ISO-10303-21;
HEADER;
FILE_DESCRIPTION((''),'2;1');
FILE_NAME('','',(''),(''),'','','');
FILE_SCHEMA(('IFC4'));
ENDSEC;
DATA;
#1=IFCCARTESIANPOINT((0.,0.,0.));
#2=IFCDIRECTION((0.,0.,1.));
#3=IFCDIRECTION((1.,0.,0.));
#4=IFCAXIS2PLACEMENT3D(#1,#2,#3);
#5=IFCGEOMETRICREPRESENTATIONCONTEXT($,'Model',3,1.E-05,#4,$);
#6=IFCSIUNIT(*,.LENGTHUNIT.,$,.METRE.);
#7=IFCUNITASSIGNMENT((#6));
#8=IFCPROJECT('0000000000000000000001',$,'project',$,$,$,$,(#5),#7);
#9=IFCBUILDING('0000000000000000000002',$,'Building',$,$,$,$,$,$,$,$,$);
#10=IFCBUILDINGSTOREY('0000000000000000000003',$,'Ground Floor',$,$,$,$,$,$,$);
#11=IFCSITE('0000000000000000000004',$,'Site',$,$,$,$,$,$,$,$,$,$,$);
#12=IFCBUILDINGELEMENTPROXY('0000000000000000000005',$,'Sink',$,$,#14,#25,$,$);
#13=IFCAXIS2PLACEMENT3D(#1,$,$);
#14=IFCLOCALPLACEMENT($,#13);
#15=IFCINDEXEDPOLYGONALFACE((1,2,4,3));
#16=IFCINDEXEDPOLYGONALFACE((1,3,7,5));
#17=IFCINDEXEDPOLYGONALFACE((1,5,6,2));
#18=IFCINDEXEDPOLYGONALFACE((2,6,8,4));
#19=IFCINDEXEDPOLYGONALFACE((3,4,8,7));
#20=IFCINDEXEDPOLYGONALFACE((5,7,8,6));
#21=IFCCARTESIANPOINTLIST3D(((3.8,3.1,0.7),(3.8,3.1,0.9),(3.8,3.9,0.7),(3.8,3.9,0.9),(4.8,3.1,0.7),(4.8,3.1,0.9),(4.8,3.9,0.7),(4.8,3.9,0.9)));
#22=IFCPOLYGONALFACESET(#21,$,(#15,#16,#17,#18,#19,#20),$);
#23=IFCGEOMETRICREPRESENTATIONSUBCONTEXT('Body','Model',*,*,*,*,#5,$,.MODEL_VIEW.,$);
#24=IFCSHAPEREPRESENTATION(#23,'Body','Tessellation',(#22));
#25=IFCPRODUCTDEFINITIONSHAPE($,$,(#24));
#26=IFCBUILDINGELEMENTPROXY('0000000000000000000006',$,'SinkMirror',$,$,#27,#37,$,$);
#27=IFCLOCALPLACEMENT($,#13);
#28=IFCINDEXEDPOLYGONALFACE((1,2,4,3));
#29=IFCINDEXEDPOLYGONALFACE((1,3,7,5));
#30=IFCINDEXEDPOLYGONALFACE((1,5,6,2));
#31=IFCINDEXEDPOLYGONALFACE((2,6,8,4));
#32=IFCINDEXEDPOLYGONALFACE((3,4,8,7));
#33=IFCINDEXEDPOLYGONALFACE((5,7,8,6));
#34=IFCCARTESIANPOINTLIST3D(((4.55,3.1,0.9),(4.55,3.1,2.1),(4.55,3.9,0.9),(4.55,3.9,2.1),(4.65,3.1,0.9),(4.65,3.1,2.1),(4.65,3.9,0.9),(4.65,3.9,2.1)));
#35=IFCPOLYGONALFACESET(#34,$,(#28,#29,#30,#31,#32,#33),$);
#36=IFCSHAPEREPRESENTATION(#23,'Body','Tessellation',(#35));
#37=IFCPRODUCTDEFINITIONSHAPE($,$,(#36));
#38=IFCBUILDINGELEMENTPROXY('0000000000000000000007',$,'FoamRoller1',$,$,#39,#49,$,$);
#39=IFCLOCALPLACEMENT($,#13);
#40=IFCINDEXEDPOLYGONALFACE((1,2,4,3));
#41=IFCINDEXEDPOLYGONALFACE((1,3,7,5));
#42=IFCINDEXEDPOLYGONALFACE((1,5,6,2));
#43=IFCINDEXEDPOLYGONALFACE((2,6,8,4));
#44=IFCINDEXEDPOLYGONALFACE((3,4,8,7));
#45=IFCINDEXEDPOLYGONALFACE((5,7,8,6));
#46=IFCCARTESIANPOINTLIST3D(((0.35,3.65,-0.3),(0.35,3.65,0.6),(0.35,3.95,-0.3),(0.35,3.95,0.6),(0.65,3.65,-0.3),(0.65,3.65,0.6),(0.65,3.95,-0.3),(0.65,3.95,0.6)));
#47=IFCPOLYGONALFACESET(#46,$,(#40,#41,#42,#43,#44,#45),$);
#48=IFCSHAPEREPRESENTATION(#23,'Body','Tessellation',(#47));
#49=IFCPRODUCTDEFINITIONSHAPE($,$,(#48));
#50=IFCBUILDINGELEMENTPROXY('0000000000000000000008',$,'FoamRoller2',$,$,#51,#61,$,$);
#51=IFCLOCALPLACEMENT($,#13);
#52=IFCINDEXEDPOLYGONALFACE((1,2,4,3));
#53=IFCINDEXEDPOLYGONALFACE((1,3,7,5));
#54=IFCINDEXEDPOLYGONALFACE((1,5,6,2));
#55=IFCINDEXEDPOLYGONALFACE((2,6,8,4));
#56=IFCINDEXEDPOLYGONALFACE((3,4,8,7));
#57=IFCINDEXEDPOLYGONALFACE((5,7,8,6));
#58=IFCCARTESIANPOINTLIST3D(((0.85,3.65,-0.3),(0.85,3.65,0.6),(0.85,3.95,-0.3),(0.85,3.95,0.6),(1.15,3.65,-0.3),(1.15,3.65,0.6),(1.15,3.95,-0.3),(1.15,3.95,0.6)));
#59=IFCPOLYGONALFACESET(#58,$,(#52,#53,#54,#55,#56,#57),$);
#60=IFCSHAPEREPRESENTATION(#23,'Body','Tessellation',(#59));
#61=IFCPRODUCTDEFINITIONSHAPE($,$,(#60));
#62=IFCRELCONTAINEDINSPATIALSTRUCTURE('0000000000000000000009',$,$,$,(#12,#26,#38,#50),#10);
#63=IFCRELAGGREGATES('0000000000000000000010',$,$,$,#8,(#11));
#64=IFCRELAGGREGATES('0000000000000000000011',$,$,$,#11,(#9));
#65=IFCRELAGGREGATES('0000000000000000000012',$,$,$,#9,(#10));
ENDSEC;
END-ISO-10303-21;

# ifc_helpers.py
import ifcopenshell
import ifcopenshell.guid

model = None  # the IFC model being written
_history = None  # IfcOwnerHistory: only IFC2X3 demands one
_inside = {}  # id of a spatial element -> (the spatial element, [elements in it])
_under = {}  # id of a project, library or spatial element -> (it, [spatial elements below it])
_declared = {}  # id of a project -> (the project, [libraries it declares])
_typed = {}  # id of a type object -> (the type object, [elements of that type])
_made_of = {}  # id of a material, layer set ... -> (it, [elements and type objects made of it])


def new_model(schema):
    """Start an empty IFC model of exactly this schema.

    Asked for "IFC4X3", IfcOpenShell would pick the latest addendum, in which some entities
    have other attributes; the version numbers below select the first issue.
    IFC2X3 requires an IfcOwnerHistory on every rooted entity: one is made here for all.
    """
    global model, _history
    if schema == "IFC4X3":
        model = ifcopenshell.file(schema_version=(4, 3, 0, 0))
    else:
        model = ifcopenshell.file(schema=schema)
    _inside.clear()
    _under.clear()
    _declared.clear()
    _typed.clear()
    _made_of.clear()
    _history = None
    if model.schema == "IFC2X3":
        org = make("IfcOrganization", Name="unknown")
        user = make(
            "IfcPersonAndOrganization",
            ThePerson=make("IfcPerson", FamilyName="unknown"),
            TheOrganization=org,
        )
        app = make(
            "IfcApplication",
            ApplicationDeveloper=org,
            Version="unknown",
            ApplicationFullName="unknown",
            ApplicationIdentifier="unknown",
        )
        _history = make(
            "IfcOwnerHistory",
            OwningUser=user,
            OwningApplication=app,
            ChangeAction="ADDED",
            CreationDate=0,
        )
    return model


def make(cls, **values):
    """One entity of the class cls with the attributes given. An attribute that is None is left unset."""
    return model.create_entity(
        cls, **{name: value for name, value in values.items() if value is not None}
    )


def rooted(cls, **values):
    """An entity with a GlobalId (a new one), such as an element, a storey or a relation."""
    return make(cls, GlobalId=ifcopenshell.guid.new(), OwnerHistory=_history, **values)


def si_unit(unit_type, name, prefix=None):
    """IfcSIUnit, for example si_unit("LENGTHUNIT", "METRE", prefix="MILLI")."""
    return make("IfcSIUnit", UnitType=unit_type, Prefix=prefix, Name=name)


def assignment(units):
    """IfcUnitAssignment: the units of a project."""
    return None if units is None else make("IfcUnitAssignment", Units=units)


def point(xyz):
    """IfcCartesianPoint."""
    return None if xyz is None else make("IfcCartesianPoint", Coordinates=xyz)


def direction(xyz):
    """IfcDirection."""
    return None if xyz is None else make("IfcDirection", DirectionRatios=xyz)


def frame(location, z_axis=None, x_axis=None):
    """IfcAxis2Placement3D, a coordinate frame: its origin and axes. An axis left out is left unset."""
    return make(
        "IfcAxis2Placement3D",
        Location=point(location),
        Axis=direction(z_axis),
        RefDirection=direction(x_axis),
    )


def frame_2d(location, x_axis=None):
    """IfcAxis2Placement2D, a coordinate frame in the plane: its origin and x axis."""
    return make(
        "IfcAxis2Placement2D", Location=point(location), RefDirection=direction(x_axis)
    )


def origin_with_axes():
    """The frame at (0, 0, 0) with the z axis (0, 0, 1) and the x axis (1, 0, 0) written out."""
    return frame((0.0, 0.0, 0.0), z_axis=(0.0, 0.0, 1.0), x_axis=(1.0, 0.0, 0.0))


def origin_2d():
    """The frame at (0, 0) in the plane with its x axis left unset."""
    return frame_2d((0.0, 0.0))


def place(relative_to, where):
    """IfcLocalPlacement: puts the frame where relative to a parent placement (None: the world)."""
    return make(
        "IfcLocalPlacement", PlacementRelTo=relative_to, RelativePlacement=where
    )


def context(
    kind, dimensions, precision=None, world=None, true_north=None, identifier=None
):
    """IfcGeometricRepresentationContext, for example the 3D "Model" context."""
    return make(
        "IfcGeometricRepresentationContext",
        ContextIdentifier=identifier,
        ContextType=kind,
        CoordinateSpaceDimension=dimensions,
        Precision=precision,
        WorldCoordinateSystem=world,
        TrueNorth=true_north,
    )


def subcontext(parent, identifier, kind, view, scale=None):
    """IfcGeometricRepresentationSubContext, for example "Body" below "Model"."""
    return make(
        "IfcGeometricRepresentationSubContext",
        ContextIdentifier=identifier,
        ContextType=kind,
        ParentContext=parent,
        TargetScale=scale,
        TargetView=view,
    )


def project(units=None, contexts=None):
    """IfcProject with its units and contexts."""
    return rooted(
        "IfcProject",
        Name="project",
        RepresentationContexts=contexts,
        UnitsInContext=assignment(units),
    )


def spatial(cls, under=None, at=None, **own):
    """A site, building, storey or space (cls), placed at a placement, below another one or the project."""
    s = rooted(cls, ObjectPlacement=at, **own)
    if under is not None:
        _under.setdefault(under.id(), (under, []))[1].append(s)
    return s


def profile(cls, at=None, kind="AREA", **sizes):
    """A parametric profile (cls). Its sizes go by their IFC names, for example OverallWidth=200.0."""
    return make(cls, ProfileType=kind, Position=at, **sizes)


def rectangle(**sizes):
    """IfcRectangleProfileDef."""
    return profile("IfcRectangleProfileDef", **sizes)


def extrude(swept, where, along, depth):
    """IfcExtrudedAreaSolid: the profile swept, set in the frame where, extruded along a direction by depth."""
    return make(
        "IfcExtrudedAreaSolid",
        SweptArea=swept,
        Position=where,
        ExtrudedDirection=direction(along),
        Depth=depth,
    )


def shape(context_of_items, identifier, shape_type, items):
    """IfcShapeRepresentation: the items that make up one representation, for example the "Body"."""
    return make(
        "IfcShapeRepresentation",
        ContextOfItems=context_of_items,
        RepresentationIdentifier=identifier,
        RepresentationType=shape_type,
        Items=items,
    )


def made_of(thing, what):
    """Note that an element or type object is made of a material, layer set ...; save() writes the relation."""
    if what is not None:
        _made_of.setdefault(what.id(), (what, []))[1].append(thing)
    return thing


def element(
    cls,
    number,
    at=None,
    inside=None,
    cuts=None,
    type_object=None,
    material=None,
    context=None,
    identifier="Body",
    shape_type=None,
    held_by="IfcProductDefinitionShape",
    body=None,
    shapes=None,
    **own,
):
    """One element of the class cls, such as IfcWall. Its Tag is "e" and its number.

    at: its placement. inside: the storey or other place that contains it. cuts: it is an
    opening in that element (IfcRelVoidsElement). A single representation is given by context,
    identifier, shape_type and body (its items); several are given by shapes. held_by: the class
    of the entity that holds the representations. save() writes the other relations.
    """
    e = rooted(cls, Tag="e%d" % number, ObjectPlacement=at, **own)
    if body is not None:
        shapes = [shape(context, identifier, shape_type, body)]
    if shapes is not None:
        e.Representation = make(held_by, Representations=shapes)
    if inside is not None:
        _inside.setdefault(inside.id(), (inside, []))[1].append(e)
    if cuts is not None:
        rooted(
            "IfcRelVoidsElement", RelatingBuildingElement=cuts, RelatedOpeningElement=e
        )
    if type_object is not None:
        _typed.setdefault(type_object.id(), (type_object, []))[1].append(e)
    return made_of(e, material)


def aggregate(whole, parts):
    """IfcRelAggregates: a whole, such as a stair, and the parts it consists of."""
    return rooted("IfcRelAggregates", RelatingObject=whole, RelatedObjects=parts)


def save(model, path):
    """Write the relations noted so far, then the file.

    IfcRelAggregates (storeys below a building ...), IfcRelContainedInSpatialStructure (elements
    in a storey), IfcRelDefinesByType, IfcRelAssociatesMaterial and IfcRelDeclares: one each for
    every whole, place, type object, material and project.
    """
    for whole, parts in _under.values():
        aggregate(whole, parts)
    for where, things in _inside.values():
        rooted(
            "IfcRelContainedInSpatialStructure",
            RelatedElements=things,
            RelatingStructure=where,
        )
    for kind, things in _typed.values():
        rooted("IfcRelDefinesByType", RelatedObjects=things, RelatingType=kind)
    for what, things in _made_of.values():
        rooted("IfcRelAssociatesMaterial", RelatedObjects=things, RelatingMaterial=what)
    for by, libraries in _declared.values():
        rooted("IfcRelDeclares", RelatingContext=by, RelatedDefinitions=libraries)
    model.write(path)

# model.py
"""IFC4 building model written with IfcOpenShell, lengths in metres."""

from ifc_helpers import new_model, si_unit, frame, origin_with_axes, origin_2d, place, context, subcontext, project, spatial, rectangle, extrude, element, save


model = new_model("IFC4")

# Units and contexts
model_context = context("Model", 3, precision=1e-05, world=origin_with_axes())
body_context = subcontext(model_context, "Body", "Model", "MODEL_VIEW")
ifc_project = project(units=[si_unit("LENGTHUNIT", "METRE")], contexts=[model_context])

# Site, building, storey
site = spatial("IfcSite", under=ifc_project, Name="Site")
building = spatial("IfcBuilding", under=site, Name="Building")
storey = spatial("IfcBuildingStorey", under=building, Name="Ground Floor")

# Building element proxies
proxy_1_placement = place(None, frame((4.3, 3.5, 0.8), z_axis=(0.0, 0.0, 1.0), x_axis=(1.0, 0.0, 0.0)))
element("IfcBuildingElementProxy", 1, at=proxy_1_placement, inside=storey, Name="Sink", context=body_context, shape_type="SweptSolid", body=[
    extrude(rectangle(XDim=1.0, YDim=0.8, at=origin_2d()), frame((0.0, 0.0, -0.1)), (0.0, 0.0, 1.0), 0.2),
])
proxy_2_placement = place(None, frame((4.6, 3.5, 1.5), z_axis=(0.0, 0.0, 1.0), x_axis=(1.0, 0.0, 0.0)))
element("IfcBuildingElementProxy", 2, at=proxy_2_placement, inside=storey, Name="SinkMirror", context=body_context, shape_type="SweptSolid", body=[
    extrude(rectangle(XDim=0.1, YDim=0.8, at=origin_2d()), frame((0.0, 0.0, -0.6)), (0.0, 0.0, 1.0), 1.2),
])
for number, where, z_axis, x_axis, name in (
    (3, (0.5, 3.8, 0.15), (0.0, 0.0, 1.0), (1.0, 0.0, 0.0), "FoamRoller1"),
    (4, (1.0, 3.8, 0.15), (0.0, 0.0, 1.0), (1.0, 0.0, 0.0), "FoamRoller2"),
):
    element("IfcBuildingElementProxy", number, at=place(None, frame(where, z_axis=z_axis, x_axis=x_axis)), inside=storey, Name=name, context=body_context, shape_type="SweptSolid", body=[
        extrude(rectangle(XDim=0.3, YDim=0.3, at=origin_2d()), frame((0.0, 0.0, -0.45)), (0.0, 0.0, 1.0), 0.9),
    ])

save(model, "model.ifc")
